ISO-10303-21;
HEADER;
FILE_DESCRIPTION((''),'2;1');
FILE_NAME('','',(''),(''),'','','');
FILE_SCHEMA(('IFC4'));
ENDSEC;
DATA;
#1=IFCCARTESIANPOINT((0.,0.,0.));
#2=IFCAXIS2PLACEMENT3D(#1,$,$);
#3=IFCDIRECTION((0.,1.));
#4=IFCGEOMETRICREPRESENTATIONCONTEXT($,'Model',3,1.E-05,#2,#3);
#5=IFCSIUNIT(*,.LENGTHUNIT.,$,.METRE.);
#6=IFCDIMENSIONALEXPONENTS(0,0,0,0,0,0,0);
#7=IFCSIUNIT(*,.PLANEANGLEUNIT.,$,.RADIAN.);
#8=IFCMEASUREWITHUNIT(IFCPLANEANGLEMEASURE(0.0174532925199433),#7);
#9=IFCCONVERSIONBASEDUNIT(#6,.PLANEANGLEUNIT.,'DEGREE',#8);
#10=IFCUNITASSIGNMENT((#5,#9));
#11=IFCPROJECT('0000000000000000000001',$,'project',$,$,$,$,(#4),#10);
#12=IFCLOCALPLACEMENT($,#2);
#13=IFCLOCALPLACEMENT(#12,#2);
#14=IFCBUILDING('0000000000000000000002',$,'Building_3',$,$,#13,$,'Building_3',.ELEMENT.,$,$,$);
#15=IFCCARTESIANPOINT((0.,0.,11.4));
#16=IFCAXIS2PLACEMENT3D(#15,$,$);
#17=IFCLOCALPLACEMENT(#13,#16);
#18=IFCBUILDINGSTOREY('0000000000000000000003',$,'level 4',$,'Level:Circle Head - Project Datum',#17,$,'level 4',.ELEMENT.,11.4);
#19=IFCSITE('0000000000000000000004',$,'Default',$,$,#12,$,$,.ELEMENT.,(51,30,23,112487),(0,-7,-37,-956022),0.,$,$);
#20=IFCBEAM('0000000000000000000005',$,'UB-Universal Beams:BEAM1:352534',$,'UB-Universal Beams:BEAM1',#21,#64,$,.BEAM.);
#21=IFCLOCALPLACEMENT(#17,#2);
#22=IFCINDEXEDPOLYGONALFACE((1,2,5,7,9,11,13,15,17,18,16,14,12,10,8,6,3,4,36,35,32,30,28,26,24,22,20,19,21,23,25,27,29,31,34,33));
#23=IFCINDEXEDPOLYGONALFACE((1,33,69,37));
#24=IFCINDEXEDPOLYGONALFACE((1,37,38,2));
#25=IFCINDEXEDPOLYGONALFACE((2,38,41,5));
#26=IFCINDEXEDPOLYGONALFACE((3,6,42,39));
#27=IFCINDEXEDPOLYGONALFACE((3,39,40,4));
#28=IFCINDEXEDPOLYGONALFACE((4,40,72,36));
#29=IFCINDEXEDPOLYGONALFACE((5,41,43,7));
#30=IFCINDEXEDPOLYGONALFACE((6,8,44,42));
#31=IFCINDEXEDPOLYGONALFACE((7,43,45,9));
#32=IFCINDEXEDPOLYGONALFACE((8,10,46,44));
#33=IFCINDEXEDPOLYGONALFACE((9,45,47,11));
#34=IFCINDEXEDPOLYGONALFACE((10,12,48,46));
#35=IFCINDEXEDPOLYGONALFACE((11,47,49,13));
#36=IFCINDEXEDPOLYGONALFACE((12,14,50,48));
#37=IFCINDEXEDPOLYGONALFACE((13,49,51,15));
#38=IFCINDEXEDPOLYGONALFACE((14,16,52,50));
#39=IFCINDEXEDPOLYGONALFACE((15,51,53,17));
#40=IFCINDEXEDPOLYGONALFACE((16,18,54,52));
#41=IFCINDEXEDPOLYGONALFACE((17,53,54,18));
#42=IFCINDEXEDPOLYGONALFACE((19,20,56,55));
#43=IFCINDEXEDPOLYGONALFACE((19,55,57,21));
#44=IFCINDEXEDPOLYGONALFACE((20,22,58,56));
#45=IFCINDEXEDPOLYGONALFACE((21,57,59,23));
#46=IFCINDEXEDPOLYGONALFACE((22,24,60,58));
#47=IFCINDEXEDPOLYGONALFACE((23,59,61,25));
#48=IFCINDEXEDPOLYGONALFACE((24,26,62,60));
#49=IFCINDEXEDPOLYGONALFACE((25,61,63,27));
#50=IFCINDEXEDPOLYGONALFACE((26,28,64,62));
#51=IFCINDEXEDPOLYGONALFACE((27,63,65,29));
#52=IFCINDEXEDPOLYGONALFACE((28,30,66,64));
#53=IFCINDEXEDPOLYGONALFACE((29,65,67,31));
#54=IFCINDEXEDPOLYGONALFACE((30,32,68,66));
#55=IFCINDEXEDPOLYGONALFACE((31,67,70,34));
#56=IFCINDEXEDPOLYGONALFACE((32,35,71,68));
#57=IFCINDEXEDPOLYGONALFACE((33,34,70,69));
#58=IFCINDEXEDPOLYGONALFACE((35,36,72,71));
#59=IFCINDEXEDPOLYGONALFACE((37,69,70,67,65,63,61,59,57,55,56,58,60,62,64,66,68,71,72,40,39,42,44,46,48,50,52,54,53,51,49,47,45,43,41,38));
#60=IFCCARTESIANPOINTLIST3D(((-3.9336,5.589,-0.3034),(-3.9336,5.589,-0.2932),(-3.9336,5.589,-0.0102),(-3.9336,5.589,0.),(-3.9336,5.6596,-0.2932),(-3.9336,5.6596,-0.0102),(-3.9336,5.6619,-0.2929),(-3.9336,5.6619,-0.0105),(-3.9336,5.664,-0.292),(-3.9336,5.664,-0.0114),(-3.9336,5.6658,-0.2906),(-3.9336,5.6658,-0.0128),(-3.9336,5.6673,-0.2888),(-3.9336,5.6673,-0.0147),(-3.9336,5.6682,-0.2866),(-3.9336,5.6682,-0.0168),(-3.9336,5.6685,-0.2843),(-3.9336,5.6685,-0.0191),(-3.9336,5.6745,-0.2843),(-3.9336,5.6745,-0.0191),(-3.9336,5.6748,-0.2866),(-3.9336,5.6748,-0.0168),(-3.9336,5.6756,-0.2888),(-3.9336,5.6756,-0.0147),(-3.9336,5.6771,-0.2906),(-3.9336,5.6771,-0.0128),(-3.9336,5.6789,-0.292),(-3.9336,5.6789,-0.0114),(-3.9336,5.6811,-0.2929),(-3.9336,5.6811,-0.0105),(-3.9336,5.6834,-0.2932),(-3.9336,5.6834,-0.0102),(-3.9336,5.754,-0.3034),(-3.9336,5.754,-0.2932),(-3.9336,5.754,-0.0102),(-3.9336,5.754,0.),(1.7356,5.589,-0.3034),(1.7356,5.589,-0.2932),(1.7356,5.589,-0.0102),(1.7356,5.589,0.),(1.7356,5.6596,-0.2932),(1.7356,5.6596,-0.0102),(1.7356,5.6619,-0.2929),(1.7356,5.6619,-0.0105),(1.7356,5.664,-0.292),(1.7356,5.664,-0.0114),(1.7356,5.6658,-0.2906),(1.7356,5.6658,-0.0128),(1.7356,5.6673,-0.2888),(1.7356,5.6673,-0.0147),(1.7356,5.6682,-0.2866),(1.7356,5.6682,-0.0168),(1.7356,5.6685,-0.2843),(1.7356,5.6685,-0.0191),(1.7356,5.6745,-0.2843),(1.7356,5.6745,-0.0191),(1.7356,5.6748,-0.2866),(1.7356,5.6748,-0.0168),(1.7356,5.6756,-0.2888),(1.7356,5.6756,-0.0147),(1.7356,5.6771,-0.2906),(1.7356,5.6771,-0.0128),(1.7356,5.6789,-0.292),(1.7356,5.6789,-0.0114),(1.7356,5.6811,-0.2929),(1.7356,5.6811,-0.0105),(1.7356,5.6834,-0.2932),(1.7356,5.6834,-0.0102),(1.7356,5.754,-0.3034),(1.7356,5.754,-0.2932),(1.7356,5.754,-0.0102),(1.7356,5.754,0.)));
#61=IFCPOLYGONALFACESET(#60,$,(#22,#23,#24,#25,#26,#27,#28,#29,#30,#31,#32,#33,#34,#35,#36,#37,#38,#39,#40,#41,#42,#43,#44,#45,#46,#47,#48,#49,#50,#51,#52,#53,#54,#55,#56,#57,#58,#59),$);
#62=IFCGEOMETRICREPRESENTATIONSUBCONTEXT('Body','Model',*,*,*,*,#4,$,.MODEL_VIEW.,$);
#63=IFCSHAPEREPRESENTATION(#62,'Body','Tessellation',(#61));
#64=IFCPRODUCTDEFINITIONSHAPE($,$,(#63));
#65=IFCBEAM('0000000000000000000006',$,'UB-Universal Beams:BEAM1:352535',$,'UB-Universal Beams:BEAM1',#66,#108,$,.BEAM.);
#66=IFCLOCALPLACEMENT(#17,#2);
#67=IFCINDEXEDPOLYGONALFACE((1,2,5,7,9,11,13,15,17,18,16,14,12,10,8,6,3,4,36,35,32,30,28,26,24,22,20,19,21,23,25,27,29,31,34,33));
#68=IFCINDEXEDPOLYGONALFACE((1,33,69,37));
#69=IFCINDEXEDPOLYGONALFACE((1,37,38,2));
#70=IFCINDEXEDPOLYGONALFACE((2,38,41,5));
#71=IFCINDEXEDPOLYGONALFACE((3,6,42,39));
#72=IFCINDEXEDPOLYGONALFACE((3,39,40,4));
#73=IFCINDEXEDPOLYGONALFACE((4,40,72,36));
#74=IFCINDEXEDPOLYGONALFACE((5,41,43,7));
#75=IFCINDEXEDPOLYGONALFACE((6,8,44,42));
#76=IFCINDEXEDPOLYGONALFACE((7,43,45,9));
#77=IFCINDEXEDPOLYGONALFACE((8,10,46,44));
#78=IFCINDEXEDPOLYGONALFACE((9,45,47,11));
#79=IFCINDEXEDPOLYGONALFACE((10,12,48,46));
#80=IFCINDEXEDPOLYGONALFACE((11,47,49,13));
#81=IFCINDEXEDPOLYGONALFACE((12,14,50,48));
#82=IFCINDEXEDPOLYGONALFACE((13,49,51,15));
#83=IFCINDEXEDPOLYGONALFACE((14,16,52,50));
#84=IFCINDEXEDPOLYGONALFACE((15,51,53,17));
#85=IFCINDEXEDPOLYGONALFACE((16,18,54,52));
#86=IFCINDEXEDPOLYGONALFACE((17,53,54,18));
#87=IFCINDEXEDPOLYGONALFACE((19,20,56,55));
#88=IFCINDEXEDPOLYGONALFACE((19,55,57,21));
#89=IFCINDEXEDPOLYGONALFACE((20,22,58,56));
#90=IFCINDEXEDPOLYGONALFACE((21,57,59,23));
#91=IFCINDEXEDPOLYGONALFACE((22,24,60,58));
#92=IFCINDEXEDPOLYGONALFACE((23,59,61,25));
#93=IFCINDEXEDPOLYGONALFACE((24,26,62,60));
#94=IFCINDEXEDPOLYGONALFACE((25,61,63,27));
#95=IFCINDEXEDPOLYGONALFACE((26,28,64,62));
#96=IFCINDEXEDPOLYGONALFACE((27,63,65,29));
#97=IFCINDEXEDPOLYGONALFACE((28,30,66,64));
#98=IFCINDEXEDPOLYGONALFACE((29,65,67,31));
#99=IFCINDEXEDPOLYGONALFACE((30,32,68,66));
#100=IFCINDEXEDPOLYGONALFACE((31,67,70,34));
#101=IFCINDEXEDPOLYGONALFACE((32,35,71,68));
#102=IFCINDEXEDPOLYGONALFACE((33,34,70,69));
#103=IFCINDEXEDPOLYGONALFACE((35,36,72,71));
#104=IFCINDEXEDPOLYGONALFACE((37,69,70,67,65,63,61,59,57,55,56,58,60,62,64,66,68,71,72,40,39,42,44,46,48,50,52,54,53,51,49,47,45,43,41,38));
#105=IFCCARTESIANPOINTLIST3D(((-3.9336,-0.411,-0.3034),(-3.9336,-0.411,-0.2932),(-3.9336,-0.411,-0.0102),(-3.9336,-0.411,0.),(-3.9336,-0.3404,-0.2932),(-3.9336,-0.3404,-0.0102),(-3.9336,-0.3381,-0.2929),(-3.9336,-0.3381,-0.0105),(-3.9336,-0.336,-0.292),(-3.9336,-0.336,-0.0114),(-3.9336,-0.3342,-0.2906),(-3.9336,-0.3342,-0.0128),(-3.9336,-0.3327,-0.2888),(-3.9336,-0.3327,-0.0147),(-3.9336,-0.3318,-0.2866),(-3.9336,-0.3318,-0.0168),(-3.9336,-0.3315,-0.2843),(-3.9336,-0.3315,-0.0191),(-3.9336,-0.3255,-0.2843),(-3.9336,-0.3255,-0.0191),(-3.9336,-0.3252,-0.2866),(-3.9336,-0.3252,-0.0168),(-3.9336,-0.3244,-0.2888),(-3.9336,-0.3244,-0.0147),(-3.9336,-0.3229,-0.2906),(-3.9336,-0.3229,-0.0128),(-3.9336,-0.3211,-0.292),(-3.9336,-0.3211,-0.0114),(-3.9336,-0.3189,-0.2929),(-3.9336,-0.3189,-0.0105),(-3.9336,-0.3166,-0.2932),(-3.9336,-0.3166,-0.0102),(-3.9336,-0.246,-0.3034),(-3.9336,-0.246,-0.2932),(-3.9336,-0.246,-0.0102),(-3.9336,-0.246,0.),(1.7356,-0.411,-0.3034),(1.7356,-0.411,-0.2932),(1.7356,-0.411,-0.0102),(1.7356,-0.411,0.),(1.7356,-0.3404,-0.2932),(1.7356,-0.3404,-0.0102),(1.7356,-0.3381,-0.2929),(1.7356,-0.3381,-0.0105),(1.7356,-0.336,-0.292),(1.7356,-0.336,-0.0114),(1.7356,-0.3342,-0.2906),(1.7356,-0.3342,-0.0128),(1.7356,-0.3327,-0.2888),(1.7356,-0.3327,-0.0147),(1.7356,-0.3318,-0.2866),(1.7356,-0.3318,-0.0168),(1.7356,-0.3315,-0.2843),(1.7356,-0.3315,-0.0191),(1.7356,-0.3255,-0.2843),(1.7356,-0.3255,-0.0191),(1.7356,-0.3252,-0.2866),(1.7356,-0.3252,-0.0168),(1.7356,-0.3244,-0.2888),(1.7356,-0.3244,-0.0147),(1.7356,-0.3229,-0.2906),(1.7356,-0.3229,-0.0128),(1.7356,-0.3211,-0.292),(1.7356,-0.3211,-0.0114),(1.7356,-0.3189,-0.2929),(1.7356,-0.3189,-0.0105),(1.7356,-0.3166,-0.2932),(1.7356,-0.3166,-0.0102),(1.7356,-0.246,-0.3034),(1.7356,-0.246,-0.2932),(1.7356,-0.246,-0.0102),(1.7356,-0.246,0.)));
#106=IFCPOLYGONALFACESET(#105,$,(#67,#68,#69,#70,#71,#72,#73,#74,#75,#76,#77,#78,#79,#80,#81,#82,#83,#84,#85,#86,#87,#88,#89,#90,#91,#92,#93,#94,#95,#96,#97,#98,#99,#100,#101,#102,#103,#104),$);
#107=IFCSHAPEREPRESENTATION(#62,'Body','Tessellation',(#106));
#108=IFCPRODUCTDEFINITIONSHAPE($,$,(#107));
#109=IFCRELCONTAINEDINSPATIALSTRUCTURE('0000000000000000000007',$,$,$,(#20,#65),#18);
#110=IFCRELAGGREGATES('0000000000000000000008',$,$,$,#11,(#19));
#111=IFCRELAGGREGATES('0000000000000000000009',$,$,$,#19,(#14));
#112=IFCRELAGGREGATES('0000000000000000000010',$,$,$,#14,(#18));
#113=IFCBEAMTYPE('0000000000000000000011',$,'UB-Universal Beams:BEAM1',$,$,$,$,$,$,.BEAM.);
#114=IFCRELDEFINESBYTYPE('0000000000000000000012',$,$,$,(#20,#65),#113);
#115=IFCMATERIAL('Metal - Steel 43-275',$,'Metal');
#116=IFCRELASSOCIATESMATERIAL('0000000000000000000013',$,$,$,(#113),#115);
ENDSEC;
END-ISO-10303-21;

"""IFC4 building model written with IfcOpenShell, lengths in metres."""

from ifc_helpers import new_model, entity, si_unit, converted_unit, direction, frame, frame_2d, origin, place, context, subcontext, project, spatial, polyline, circle_curve, parameter, trimmed, segment, composite_curve, outline, extrude, source, transform, mapped, material, material_profile, profile_set, type_object, type_shapes, element, save


model = new_model("IFC4")

# Units and contexts
model_context = context("Model", 3, precision=1e-05, world=origin(), true_north=direction((0.0, 1.0)))
body_context = subcontext(model_context, "Body", "Model", "MODEL_VIEW")
ifc_project = project(units=[si_unit("LENGTHUNIT", "METRE"), converted_unit("PLANEANGLEUNIT", "DEGREE", entity("IfcPlaneAngleMeasure", 0.0174532925199433), si_unit("PLANEANGLEUNIT", "RADIAN"), dimensions=[0, 0, 0, 0, 0, 0, 0])], contexts=[model_context])

# Site, building, storey
site_placement = place(None, origin())
site = spatial("IfcSite", under=ifc_project, at=site_placement, Name="Default", CompositionType="ELEMENT", RefLatitude=(51, 30, 23, 112487), RefLongitude=(0, -7, -37, -956022), RefElevation=0.0)
building_placement = place(site_placement, origin())
building = spatial("IfcBuilding", under=site, at=building_placement, Name="Building_3", LongName="Building_3", CompositionType="ELEMENT")
storey_placement = place(building_placement, frame((0.0, 0.0, 11.4)))
storey = spatial("IfcBuildingStorey", under=building, at=storey_placement, Name="level 4", ObjectType="Level:Circle Head - Project Datum", LongName="level 4", CompositionType="ELEMENT", Elevation=11.4)

# Shared definitions
ifc_material_1 = material(Name="Metal - Steel 43-275", Category="Metal")

# Beams
ifc_material_profile_1 = material_profile(ifc_material_1, outline(composite_curve([segment(polyline([(-0.0825, -0.1415), (-0.0825, -0.1517)]), True, "CONTINUOUS"), segment(polyline([(-0.0825, -0.1517), (0.0825, -0.1517)]), True, "CONTINUOUS"), segment(polyline([(0.0825, -0.1517), (0.0825, -0.1415)]), True, "CONTINUOUS"), segment(polyline([(0.0825, -0.1415), (0.0119, -0.1415)]), True, "CONTINUOUS"), segment(trimmed(circle_curve(frame_2d((0.0119, -0.1326), x_axis=(1.0, 0.0)), 0.0089), [parameter(180.0)], [parameter(270.0)], True, "PARAMETER"), False, "CONTINUOUS"), segment(polyline([(0.003, -0.1326), (0.003, 0.1326)]), True, "CONTINUOUS"), segment(trimmed(circle_curve(frame_2d((0.0119, 0.1326), x_axis=(1.0, 0.0)), 0.0089), [parameter(90.0)], [parameter(180.0)], True, "PARAMETER"), False, "CONTINUOUS"), segment(polyline([(0.0119, 0.1415), (0.0825, 0.1415)]), True, "CONTINUOUS"), segment(polyline([(0.0825, 0.1415), (0.0825, 0.1517)]), True, "CONTINUOUS"), segment(polyline([(0.0825, 0.1517), (-0.0825, 0.1517)]), True, "CONTINUOUS"), segment(polyline([(-0.0825, 0.1517), (-0.0825, 0.1415)]), True, "CONTINUOUS"), segment(polyline([(-0.0825, 0.1415), (-0.0119, 0.1415)]), True, "CONTINUOUS"), segment(trimmed(circle_curve(frame_2d((-0.0119, 0.1326), x_axis=(1.0, 0.0)), 0.0089), [parameter(360.0)], [parameter(90.0)], True, "PARAMETER"), False, "CONTINUOUS"), segment(polyline([(-0.003, 0.1326), (-0.003, -0.1326)]), True, "CONTINUOUS"), segment(trimmed(circle_curve(frame_2d((-0.0119, -0.1326), x_axis=(1.0, 0.0)), 0.0089), [parameter(270.0)], [parameter(360.0)], True, "PARAMETER"), False, "CONTINUOUS"), segment(polyline([(-0.0119, -0.1415), (-0.0825, -0.1415)]), True, "CONTINUOUS")], self_intersect=False)), Name="BEAM1")
ifc_profile_set_1 = profile_set([ifc_material_profile_1], Name="BEAM1")
beam_type_1 = type_object("IfcBeamType", Name="UB-Universal Beams:BEAM1", PredefinedType="BEAM", material=ifc_profile_set_1)
shared_shape_1 = source(origin(), body_context, "Body", "SweptSolid", [
    extrude(outline(composite_curve([segment(polyline([(-0.0825, -0.1415), (-0.0825, -0.1517)]), True, "CONTINUOUS"), segment(polyline([(-0.0825, -0.1517), (0.0825, -0.1517)]), True, "CONTINUOUS"), segment(polyline([(0.0825, -0.1517), (0.0825, -0.1415)]), True, "CONTINUOUS"), segment(polyline([(0.0825, -0.1415), (0.0119, -0.1415)]), True, "CONTINUOUS"), segment(trimmed(circle_curve(frame_2d((0.0119, -0.1326), x_axis=(0.0, -1.0)), 0.0089), [parameter(270.0)], [parameter(360.0)], True, "PARAMETER"), False, "CONTINUOUS"), segment(polyline([(0.003, -0.1326), (0.003, 0.1326)]), True, "CONTINUOUS"), segment(trimmed(circle_curve(frame_2d((0.0119, 0.1326), x_axis=(-1.0, 0.0)), 0.0089), [parameter(270.0)], [parameter(360.0)], True, "PARAMETER"), False, "CONTINUOUS"), segment(polyline([(0.0119, 0.1415), (0.0825, 0.1415)]), True, "CONTINUOUS"), segment(polyline([(0.0825, 0.1415), (0.0825, 0.1517)]), True, "CONTINUOUS"), segment(polyline([(0.0825, 0.1517), (-0.0825, 0.1517)]), True, "CONTINUOUS"), segment(polyline([(-0.0825, 0.1517), (-0.0825, 0.1415)]), True, "CONTINUOUS"), segment(polyline([(-0.0825, 0.1415), (-0.0119, 0.1415)]), True, "CONTINUOUS"), segment(trimmed(circle_curve(frame_2d((-0.0119, 0.1326), x_axis=(0.0, 1.0)), 0.0089), [parameter(270.0)], [parameter(360.0)], True, "PARAMETER"), False, "CONTINUOUS"), segment(polyline([(-0.003, 0.1326), (-0.003, -0.1326)]), True, "CONTINUOUS"), segment(trimmed(circle_curve(frame_2d((-0.0119, -0.1326), x_axis=(1.0, 0.0)), 0.0089), [parameter(270.0)], [parameter(0.0)], True, "PARAMETER"), False, "CONTINUOUS"), segment(polyline([(-0.0119, -0.1415), (-0.0825, -0.1415)]), True, "CONTINUOUS")], self_intersect=False)), frame((-2.8346, 0.0, 0.0), z_axis=(-1.0, 0.0, 0.0), x_axis=(0.0, -1.0, 0.0)), (0.0, 0.0, -1.0), 5.6692),
])
type_shapes(beam_type_1, [shared_shape_1])
beam_1_placement = place(storey_placement, frame((-1.099, 5.6715, -0.1517), z_axis=(0.0, 0.0, 1.0), x_axis=(-1.0, 0.0, 0.0)))
element("IfcBeam", 1, at=beam_1_placement, inside=storey, type_object=beam_type_1, Name="UB-Universal Beams:BEAM1:352534", ObjectType="UB-Universal Beams:BEAM1", PredefinedType="BEAM", context=body_context, shape_type="MappedRepresentation", body=[
    mapped(shared_shape_1, transform((0.0, 0.0, 0.0), scale=1.0)),
])
beam_2_placement = place(storey_placement, frame((-1.099, -0.3285, -0.1517)))
element("IfcBeam", 2, at=beam_2_placement, inside=storey, type_object=beam_type_1, Name="UB-Universal Beams:BEAM1:352535", ObjectType="UB-Universal Beams:BEAM1", PredefinedType="BEAM", context=body_context, shape_type="MappedRepresentation", body=[
    mapped(shared_shape_1, transform((0.0, 0.0, 0.0), scale=1.0)),
])

save(model, "model.ifc")
